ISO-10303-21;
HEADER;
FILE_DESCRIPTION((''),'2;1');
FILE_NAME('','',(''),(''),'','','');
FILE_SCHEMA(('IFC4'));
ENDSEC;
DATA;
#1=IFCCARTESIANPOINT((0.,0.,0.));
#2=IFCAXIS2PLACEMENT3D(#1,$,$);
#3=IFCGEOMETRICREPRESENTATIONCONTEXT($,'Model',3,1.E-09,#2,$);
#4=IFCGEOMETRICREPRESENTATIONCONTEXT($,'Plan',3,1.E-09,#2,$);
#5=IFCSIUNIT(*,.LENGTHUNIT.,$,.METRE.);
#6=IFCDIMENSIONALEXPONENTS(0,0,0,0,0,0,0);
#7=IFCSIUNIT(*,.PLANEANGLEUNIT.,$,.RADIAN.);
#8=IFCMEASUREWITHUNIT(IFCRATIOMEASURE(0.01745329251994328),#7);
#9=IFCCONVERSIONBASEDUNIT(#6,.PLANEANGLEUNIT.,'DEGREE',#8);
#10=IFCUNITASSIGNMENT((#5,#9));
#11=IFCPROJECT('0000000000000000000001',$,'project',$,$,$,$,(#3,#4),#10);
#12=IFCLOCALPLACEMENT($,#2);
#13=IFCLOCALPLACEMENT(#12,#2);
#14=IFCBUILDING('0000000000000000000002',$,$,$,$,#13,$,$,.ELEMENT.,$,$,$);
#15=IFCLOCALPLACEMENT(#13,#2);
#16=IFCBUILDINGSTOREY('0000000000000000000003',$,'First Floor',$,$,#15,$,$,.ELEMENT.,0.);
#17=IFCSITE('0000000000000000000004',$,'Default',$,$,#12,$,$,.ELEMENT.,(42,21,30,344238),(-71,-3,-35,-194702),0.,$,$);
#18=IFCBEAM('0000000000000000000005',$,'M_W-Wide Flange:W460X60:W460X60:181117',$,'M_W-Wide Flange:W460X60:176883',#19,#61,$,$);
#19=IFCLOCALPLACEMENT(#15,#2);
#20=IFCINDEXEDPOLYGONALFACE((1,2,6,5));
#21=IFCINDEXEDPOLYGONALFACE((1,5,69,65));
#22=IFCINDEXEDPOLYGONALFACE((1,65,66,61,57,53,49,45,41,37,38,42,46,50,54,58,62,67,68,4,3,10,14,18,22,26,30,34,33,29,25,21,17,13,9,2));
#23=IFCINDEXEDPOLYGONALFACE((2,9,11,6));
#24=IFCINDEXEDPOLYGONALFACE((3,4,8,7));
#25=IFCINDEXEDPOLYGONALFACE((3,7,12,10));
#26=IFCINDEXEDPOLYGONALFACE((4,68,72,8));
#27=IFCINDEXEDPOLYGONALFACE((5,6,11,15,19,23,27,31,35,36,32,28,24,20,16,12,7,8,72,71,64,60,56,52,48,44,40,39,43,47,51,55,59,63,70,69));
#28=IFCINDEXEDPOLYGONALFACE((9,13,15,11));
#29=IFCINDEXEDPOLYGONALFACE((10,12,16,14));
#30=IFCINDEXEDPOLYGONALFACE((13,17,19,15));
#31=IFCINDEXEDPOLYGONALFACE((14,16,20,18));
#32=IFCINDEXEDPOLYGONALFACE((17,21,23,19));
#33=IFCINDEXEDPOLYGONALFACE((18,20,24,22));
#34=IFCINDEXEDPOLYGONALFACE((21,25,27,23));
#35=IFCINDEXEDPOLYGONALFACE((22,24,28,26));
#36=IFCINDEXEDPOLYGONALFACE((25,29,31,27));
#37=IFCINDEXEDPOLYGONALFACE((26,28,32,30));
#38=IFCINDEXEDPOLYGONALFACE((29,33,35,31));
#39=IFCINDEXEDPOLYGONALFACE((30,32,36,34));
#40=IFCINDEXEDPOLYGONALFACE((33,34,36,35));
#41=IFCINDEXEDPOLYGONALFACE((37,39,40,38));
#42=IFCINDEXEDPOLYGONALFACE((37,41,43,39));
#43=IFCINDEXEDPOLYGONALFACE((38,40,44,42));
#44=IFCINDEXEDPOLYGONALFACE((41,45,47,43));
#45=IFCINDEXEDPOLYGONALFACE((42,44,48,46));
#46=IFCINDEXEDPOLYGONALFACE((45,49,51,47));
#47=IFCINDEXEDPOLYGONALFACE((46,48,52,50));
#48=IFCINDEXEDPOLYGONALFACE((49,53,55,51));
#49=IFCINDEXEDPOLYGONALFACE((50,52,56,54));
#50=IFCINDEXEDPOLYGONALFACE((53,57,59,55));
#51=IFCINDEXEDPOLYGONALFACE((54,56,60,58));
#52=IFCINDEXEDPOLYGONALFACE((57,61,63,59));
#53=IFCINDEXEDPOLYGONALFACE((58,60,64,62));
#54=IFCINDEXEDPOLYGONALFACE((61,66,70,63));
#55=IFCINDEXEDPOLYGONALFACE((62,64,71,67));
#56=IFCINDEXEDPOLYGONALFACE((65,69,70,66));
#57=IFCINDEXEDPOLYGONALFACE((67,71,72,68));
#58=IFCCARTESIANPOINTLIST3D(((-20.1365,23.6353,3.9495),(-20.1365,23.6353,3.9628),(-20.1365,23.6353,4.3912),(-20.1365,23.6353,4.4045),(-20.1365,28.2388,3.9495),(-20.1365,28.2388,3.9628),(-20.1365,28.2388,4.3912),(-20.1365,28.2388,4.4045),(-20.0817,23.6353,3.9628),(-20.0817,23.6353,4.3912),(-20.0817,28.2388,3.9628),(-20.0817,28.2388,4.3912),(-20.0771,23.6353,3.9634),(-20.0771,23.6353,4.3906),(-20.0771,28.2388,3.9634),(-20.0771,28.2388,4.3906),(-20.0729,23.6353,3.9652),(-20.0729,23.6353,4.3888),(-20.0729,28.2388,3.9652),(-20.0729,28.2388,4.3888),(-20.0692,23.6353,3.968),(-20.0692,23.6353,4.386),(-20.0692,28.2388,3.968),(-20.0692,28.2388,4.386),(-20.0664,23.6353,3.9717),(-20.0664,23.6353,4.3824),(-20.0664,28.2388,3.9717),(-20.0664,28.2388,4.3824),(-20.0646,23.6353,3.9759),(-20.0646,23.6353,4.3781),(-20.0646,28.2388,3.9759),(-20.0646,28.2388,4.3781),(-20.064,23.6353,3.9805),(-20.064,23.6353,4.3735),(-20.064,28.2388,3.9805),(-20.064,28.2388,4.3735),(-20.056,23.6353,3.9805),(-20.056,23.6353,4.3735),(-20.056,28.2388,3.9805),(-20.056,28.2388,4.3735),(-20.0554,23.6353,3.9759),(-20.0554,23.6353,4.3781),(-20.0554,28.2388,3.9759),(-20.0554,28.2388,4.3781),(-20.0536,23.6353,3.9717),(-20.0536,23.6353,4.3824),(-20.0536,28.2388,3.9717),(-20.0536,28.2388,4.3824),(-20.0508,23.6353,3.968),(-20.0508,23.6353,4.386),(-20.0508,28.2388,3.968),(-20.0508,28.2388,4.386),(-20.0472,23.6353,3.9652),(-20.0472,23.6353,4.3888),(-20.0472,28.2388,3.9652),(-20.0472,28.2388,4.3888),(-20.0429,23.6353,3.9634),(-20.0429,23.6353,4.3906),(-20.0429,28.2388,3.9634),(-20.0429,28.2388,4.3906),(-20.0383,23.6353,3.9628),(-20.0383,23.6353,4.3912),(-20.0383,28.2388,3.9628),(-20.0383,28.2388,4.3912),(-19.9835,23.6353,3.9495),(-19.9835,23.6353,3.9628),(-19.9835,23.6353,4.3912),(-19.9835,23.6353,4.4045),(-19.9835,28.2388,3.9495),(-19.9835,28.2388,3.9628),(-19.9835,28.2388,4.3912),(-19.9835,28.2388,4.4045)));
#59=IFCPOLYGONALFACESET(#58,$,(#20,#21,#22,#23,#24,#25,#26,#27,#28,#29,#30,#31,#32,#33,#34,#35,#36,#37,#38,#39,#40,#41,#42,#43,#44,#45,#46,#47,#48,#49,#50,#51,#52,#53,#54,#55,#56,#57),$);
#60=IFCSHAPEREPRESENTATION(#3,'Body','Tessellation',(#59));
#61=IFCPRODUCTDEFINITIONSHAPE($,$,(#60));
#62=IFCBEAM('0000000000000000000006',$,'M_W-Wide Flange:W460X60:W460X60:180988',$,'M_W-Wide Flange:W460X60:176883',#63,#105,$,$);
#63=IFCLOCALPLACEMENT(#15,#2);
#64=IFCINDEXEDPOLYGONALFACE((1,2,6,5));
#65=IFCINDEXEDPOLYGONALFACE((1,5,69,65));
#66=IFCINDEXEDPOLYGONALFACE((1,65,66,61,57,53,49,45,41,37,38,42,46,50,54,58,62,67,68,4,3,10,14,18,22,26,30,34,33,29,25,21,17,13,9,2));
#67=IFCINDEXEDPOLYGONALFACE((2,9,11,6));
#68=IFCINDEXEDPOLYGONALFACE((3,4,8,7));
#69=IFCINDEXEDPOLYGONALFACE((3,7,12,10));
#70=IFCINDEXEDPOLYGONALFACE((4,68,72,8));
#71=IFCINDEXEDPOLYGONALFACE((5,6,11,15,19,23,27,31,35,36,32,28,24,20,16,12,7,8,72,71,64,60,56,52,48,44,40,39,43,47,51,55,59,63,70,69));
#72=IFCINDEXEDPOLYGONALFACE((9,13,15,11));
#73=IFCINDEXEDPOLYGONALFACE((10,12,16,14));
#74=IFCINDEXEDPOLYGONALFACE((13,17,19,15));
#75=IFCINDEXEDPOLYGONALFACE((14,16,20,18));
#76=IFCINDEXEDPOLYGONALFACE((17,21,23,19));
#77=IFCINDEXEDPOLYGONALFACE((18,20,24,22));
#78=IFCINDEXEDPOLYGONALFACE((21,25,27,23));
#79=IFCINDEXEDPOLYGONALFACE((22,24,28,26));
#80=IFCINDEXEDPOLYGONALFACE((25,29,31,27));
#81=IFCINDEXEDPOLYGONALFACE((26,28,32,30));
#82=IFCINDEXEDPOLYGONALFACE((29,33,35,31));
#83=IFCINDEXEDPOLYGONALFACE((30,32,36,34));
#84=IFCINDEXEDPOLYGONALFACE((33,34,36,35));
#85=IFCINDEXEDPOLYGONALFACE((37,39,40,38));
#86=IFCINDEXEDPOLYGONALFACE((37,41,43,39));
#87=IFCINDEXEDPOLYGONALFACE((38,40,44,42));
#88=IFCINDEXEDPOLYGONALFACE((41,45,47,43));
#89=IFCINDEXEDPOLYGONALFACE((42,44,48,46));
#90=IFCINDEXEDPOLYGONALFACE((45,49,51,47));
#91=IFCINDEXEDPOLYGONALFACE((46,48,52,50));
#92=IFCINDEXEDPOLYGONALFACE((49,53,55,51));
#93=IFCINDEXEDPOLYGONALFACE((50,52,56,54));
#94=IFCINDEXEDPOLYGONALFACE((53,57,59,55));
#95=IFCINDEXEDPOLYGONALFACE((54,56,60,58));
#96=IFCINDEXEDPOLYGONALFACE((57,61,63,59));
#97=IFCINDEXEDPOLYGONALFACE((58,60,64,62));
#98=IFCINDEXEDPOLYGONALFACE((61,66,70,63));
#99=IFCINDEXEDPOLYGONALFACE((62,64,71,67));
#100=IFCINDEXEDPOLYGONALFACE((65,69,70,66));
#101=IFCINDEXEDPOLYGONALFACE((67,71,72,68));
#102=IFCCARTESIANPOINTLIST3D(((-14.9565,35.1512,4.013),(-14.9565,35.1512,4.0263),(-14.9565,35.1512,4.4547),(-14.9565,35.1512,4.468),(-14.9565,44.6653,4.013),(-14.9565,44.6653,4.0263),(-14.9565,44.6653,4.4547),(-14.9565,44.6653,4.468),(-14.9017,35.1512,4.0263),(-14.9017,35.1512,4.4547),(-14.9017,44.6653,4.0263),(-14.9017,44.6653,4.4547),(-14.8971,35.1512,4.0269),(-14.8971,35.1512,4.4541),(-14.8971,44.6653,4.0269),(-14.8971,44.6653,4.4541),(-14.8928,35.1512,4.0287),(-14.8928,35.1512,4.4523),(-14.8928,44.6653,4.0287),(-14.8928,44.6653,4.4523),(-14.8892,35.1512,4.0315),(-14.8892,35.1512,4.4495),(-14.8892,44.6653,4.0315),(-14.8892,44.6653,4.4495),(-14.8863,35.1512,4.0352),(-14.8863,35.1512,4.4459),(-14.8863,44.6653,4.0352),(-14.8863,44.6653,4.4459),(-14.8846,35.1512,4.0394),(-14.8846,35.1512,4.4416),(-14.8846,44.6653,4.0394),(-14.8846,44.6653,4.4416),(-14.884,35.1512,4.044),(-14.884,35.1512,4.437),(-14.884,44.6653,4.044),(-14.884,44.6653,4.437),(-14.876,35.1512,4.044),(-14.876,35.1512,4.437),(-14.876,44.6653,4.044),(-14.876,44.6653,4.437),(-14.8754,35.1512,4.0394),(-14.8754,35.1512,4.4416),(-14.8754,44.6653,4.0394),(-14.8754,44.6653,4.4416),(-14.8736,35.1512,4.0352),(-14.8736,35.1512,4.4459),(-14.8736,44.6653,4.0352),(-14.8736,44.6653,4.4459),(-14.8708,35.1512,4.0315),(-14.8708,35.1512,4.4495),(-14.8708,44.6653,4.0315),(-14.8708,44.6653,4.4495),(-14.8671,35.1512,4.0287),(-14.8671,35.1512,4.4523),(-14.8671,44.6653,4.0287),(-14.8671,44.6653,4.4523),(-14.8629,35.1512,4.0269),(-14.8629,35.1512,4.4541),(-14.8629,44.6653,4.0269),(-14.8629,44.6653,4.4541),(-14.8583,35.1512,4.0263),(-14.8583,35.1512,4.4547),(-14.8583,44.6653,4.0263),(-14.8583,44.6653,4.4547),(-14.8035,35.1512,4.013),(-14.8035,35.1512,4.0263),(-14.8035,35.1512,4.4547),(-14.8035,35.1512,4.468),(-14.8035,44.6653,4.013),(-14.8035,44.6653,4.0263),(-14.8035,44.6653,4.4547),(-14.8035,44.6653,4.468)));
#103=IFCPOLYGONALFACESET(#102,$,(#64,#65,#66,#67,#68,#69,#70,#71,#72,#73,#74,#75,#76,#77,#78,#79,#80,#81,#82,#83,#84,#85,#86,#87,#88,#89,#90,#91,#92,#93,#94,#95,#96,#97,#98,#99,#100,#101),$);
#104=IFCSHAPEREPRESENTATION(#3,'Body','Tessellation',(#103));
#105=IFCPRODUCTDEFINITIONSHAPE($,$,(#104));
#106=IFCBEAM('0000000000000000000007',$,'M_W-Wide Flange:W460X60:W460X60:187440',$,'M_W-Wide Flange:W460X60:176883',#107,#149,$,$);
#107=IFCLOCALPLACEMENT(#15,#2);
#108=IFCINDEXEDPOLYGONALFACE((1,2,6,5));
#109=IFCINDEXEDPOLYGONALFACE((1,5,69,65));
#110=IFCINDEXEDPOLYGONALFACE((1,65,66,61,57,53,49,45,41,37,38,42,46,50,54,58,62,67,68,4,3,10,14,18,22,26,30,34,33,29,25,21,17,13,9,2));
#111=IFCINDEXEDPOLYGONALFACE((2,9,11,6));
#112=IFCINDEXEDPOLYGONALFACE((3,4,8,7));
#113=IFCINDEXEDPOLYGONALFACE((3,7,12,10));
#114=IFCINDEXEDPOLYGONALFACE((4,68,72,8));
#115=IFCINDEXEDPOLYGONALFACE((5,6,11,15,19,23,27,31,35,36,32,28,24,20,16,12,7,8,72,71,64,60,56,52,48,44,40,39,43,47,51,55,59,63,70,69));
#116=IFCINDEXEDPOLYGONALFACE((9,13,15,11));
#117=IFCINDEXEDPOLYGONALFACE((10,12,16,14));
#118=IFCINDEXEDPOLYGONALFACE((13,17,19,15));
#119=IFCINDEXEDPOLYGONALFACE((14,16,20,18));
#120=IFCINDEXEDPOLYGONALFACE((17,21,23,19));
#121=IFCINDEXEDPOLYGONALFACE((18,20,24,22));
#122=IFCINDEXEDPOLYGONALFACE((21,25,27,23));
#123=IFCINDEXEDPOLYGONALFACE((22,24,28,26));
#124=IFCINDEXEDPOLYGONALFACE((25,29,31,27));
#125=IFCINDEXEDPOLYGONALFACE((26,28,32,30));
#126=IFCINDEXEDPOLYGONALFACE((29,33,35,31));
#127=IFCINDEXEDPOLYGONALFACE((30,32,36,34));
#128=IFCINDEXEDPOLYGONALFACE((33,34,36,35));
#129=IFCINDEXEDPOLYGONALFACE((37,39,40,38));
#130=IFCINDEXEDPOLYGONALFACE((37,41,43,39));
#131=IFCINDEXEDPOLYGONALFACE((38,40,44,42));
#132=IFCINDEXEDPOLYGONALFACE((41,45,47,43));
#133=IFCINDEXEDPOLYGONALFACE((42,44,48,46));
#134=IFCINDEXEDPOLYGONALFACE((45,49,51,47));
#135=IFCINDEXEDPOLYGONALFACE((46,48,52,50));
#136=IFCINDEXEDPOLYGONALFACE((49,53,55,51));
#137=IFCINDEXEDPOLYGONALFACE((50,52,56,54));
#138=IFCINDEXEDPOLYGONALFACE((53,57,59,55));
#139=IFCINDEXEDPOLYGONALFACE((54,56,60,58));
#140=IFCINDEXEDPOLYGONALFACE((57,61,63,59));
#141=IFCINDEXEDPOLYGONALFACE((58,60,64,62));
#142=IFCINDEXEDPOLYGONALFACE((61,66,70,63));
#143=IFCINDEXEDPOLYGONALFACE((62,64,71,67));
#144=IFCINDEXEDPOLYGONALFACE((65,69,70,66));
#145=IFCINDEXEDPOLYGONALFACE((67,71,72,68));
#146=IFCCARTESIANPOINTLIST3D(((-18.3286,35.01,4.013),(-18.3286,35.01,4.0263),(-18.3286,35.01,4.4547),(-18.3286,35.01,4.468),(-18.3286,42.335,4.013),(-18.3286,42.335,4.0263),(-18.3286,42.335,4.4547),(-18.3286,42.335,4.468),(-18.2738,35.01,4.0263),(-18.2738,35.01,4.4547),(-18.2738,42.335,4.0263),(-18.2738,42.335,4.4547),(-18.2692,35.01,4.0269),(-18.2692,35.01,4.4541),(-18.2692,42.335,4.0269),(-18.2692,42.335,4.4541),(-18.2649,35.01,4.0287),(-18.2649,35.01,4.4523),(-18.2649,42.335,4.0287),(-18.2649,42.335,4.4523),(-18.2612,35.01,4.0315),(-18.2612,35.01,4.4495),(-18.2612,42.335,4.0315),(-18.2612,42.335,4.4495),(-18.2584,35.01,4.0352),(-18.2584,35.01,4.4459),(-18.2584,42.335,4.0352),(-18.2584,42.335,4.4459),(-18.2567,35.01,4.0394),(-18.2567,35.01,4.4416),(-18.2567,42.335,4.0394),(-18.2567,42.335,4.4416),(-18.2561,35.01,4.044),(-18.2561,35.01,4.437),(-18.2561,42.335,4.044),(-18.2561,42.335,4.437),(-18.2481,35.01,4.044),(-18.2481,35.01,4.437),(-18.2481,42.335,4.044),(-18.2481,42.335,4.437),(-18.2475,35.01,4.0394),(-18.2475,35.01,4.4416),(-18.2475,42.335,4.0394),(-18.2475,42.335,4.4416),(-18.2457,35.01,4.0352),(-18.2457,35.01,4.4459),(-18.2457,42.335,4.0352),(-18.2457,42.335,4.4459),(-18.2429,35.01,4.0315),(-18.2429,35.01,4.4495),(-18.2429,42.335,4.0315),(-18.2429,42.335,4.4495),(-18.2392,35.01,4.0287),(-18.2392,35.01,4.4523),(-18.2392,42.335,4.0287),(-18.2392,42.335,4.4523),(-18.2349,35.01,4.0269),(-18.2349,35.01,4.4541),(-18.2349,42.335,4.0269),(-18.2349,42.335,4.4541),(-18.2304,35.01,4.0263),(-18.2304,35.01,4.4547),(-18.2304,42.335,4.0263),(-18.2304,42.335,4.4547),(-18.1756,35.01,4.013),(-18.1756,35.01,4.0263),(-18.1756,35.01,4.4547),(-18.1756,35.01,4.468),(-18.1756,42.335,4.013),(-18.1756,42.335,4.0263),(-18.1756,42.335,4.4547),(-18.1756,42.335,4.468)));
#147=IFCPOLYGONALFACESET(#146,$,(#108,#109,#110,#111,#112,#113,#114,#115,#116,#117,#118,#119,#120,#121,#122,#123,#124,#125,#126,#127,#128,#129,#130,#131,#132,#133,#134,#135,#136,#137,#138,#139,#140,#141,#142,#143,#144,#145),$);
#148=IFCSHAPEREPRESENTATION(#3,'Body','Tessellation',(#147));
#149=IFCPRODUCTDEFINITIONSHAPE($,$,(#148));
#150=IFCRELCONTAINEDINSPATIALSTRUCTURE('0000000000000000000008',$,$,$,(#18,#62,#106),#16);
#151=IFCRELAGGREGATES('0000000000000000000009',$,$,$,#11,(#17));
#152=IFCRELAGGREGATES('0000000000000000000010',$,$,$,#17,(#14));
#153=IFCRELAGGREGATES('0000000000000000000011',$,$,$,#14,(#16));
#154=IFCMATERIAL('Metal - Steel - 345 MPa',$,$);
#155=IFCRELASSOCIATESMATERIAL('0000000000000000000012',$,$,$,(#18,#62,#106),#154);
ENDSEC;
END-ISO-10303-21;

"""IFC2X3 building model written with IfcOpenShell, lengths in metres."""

from ifc_helpers import new_model, entity, si_unit, converted_unit, frame, frame_2d, origin, place, context, project, spatial, polyline, circle_curve, parameter, trimmed, segment, composite_curve, outline, extrude, material, element, save


model = new_model("IFC2X3")

# Units and contexts
model_context = context("Model", 3, precision=1e-09, world=origin())
plan_context = context("Plan", 3, precision=1e-09, world=origin())
ifc_project = project(units=[si_unit("LENGTHUNIT", "METRE"), converted_unit("PLANEANGLEUNIT", "DEGREE", entity("IfcRatioMeasure", 0.01745329251994328), si_unit("PLANEANGLEUNIT", "RADIAN"), dimensions=[0, 0, 0, 0, 0, 0, 0])], contexts=[model_context, plan_context])

# Site, building, storey
site_placement = place(None, origin())
site = spatial("IfcSite", under=ifc_project, at=site_placement, Name="Default", CompositionType="ELEMENT", RefLatitude=(42, 21, 30, 344238), RefLongitude=(-71, -3, -35, -194702), RefElevation=0.0)
building_placement = place(site_placement, origin())
building = spatial("IfcBuilding", under=site, at=building_placement, CompositionType="ELEMENT")
storey_placement = place(building_placement, origin())
storey = spatial("IfcBuildingStorey", under=building, at=storey_placement, Name="First Floor", CompositionType="ELEMENT", Elevation=0.0)

# Shared definitions
ifc_material = material(Name="Metal - Steel - 345 MPa")

# Beams
beam_1_placement = place(storey_placement, frame((-20.06, 28.3828, 4.4045), z_axis=(0.0, 0.0, 1.0), x_axis=(-1.0, 0.0, 0.0)))
element("IfcBeam", 1, at=beam_1_placement, inside=storey, material=ifc_material, Name="M_W-Wide Flange:W460X60:W460X60:181117", ObjectType="M_W-Wide Flange:W460X60:176883", context=model_context, shape_type="SweptSolid", body=[
    extrude(outline(composite_curve([segment(polyline([(0.2142, -0.0765), (0.2275, -0.0765)]), True, "CONTINUOUS"), segment(polyline([(0.2275, -0.0765), (0.2275, 0.0765)]), True, "CONTINUOUS"), segment(polyline([(0.2275, 0.0765), (0.2142, 0.0765)]), True, "CONTINUOUS"), segment(polyline([(0.2142, 0.0765), (0.2142, 0.0217)]), True, "CONTINUOUS"), segment(trimmed(circle_curve(frame_2d((0.1965, 0.0217), x_axis=(1.0, 0.0)), 0.0177), [parameter(270.0)], [parameter(360.0)], True, "PARAMETER"), False, "CONTINUOUS"), segment(polyline([(0.1965, 0.004), (-0.1965, 0.004)]), True, "CONTINUOUS"), segment(trimmed(circle_curve(frame_2d((-0.1965, 0.0217), x_axis=(0.0, -1.0)), 0.0177), [parameter(270.0)], [parameter(360.0)], True, "PARAMETER"), False, "CONTINUOUS"), segment(polyline([(-0.2142, 0.0217), (-0.2142, 0.0765)]), True, "CONTINUOUS"), segment(polyline([(-0.2142, 0.0765), (-0.2275, 0.0765)]), True, "CONTINUOUS"), segment(polyline([(-0.2275, 0.0765), (-0.2275, -0.0765)]), True, "CONTINUOUS"), segment(polyline([(-0.2275, -0.0765), (-0.2142, -0.0765)]), True, "CONTINUOUS"), segment(polyline([(-0.2142, -0.0765), (-0.2142, -0.0217)]), True, "CONTINUOUS"), segment(trimmed(circle_curve(frame_2d((-0.1965, -0.0217), x_axis=(-1.0, 0.0)), 0.0177), [parameter(270.0)], [parameter(360.0)], True, "PARAMETER"), False, "CONTINUOUS"), segment(polyline([(-0.1965, -0.004), (0.1965, -0.004)]), True, "CONTINUOUS"), segment(trimmed(circle_curve(frame_2d((0.1965, -0.0217), x_axis=(0.0, 1.0)), 0.0177), [parameter(270.0)], [parameter(0.0)], True, "PARAMETER"), False, "CONTINUOUS"), segment(polyline([(0.2142, -0.0217), (0.2142, -0.0765)]), True, "CONTINUOUS")], self_intersect=False)), frame((0.0, 4.7475, -0.2275), z_axis=(0.0, -1.0, 0.0), x_axis=(0.0, 0.0, -1.0)), (0.0, 0.0, 1.0), 4.6035),
])
beam_2_placement = place(storey_placement, frame((-14.88, 44.7814, 4.468), z_axis=(0.0, 0.0, 1.0), x_axis=(-1.0, 0.0, 0.0)))
element("IfcBeam", 2, at=beam_2_placement, inside=storey, material=ifc_material, Name="M_W-Wide Flange:W460X60:W460X60:180988", ObjectType="M_W-Wide Flange:W460X60:176883", context=model_context, shape_type="SweptSolid", body=[
    extrude(outline(composite_curve([segment(polyline([(0.2142, -0.0765), (0.2275, -0.0765)]), True, "CONTINUOUS"), segment(polyline([(0.2275, -0.0765), (0.2275, 0.0765)]), True, "CONTINUOUS"), segment(polyline([(0.2275, 0.0765), (0.2142, 0.0765)]), True, "CONTINUOUS"), segment(polyline([(0.2142, 0.0765), (0.2142, 0.0217)]), True, "CONTINUOUS"), segment(trimmed(circle_curve(frame_2d((0.1965, 0.0217), x_axis=(1.0, 0.0)), 0.0177), [parameter(270.0)], [parameter(360.0)], True, "PARAMETER"), False, "CONTINUOUS"), segment(polyline([(0.1965, 0.004), (-0.1965, 0.004)]), True, "CONTINUOUS"), segment(trimmed(circle_curve(frame_2d((-0.1965, 0.0217), x_axis=(0.0, -1.0)), 0.0177), [parameter(270.0)], [parameter(360.0)], True, "PARAMETER"), False, "CONTINUOUS"), segment(polyline([(-0.2142, 0.0217), (-0.2142, 0.0765)]), True, "CONTINUOUS"), segment(polyline([(-0.2142, 0.0765), (-0.2275, 0.0765)]), True, "CONTINUOUS"), segment(polyline([(-0.2275, 0.0765), (-0.2275, -0.0765)]), True, "CONTINUOUS"), segment(polyline([(-0.2275, -0.0765), (-0.2142, -0.0765)]), True, "CONTINUOUS"), segment(polyline([(-0.2142, -0.0765), (-0.2142, -0.0217)]), True, "CONTINUOUS"), segment(trimmed(circle_curve(frame_2d((-0.1965, -0.0217), x_axis=(-1.0, 0.0)), 0.0177), [parameter(270.0)], [parameter(360.0)], True, "PARAMETER"), False, "CONTINUOUS"), segment(polyline([(-0.1965, -0.004), (0.1965, -0.004)]), True, "CONTINUOUS"), segment(trimmed(circle_curve(frame_2d((0.1965, -0.0217), x_axis=(0.0, 1.0)), 0.0177), [parameter(270.0)], [parameter(0.0)], True, "PARAMETER"), False, "CONTINUOUS"), segment(polyline([(0.2142, -0.0217), (0.2142, -0.0765)]), True, "CONTINUOUS")], self_intersect=False)), frame((0.0, 9.6302, -0.2275), z_axis=(0.0, -1.0, 0.0), x_axis=(0.0, 0.0, -1.0)), (0.0, 0.0, 1.0), 9.5141),
])
beam_3_placement = place(storey_placement, frame((-18.2521, 35.1606, 4.468)))
element("IfcBeam", 3, at=beam_3_placement, inside=storey, material=ifc_material, Name="M_W-Wide Flange:W460X60:W460X60:187440", ObjectType="M_W-Wide Flange:W460X60:176883", context=model_context, shape_type="SweptSolid", body=[
    extrude(outline(composite_curve([segment(polyline([(-0.0765, -0.2142), (-0.0765, -0.2275)]), True, "CONTINUOUS"), segment(polyline([(-0.0765, -0.2275), (0.0765, -0.2275)]), True, "CONTINUOUS"), segment(polyline([(0.0765, -0.2275), (0.0765, -0.2142)]), True, "CONTINUOUS"), segment(polyline([(0.0765, -0.2142), (0.0217, -0.2142)]), True, "CONTINUOUS"), segment(trimmed(circle_curve(frame_2d((0.0217, -0.1965), x_axis=(1.0, 0.0)), 0.0177), [parameter(180.0)], [parameter(270.0)], True, "PARAMETER"), False, "CONTINUOUS"), segment(polyline([(0.004, -0.1965), (0.004, 0.1965)]), True, "CONTINUOUS"), segment(trimmed(circle_curve(frame_2d((0.0217, 0.1965), x_axis=(1.0, 0.0)), 0.0177), [parameter(90.0)], [parameter(180.0)], True, "PARAMETER"), False, "CONTINUOUS"), segment(polyline([(0.0217, 0.2142), (0.0765, 0.2142)]), True, "CONTINUOUS"), segment(polyline([(0.0765, 0.2142), (0.0765, 0.2275)]), True, "CONTINUOUS"), segment(polyline([(0.0765, 0.2275), (-0.0765, 0.2275)]), True, "CONTINUOUS"), segment(polyline([(-0.0765, 0.2275), (-0.0765, 0.2142)]), True, "CONTINUOUS"), segment(polyline([(-0.0765, 0.2142), (-0.0217, 0.2142)]), True, "CONTINUOUS"), segment(trimmed(circle_curve(frame_2d((-0.0217, 0.1965), x_axis=(1.0, 0.0)), 0.0177), [parameter(360.0)], [parameter(90.0)], True, "PARAMETER"), False, "CONTINUOUS"), segment(polyline([(-0.004, 0.1965), (-0.004, -0.1965)]), True, "CONTINUOUS"), segment(trimmed(circle_curve(frame_2d((-0.0217, -0.1965), x_axis=(1.0, 0.0)), 0.0177), [parameter(270.0)], [parameter(0.0)], True, "PARAMETER"), False, "CONTINUOUS"), segment(polyline([(-0.0217, -0.2142), (-0.0765, -0.2142)]), True, "CONTINUOUS")], self_intersect=False)), frame((0.0, -0.1506, -0.2275), z_axis=(0.0, -1.0, 0.0), x_axis=(1.0, 0.0, 0.0)), (0.0, 0.0, -1.0), 7.325),
])

save(model, "model.ifc")
